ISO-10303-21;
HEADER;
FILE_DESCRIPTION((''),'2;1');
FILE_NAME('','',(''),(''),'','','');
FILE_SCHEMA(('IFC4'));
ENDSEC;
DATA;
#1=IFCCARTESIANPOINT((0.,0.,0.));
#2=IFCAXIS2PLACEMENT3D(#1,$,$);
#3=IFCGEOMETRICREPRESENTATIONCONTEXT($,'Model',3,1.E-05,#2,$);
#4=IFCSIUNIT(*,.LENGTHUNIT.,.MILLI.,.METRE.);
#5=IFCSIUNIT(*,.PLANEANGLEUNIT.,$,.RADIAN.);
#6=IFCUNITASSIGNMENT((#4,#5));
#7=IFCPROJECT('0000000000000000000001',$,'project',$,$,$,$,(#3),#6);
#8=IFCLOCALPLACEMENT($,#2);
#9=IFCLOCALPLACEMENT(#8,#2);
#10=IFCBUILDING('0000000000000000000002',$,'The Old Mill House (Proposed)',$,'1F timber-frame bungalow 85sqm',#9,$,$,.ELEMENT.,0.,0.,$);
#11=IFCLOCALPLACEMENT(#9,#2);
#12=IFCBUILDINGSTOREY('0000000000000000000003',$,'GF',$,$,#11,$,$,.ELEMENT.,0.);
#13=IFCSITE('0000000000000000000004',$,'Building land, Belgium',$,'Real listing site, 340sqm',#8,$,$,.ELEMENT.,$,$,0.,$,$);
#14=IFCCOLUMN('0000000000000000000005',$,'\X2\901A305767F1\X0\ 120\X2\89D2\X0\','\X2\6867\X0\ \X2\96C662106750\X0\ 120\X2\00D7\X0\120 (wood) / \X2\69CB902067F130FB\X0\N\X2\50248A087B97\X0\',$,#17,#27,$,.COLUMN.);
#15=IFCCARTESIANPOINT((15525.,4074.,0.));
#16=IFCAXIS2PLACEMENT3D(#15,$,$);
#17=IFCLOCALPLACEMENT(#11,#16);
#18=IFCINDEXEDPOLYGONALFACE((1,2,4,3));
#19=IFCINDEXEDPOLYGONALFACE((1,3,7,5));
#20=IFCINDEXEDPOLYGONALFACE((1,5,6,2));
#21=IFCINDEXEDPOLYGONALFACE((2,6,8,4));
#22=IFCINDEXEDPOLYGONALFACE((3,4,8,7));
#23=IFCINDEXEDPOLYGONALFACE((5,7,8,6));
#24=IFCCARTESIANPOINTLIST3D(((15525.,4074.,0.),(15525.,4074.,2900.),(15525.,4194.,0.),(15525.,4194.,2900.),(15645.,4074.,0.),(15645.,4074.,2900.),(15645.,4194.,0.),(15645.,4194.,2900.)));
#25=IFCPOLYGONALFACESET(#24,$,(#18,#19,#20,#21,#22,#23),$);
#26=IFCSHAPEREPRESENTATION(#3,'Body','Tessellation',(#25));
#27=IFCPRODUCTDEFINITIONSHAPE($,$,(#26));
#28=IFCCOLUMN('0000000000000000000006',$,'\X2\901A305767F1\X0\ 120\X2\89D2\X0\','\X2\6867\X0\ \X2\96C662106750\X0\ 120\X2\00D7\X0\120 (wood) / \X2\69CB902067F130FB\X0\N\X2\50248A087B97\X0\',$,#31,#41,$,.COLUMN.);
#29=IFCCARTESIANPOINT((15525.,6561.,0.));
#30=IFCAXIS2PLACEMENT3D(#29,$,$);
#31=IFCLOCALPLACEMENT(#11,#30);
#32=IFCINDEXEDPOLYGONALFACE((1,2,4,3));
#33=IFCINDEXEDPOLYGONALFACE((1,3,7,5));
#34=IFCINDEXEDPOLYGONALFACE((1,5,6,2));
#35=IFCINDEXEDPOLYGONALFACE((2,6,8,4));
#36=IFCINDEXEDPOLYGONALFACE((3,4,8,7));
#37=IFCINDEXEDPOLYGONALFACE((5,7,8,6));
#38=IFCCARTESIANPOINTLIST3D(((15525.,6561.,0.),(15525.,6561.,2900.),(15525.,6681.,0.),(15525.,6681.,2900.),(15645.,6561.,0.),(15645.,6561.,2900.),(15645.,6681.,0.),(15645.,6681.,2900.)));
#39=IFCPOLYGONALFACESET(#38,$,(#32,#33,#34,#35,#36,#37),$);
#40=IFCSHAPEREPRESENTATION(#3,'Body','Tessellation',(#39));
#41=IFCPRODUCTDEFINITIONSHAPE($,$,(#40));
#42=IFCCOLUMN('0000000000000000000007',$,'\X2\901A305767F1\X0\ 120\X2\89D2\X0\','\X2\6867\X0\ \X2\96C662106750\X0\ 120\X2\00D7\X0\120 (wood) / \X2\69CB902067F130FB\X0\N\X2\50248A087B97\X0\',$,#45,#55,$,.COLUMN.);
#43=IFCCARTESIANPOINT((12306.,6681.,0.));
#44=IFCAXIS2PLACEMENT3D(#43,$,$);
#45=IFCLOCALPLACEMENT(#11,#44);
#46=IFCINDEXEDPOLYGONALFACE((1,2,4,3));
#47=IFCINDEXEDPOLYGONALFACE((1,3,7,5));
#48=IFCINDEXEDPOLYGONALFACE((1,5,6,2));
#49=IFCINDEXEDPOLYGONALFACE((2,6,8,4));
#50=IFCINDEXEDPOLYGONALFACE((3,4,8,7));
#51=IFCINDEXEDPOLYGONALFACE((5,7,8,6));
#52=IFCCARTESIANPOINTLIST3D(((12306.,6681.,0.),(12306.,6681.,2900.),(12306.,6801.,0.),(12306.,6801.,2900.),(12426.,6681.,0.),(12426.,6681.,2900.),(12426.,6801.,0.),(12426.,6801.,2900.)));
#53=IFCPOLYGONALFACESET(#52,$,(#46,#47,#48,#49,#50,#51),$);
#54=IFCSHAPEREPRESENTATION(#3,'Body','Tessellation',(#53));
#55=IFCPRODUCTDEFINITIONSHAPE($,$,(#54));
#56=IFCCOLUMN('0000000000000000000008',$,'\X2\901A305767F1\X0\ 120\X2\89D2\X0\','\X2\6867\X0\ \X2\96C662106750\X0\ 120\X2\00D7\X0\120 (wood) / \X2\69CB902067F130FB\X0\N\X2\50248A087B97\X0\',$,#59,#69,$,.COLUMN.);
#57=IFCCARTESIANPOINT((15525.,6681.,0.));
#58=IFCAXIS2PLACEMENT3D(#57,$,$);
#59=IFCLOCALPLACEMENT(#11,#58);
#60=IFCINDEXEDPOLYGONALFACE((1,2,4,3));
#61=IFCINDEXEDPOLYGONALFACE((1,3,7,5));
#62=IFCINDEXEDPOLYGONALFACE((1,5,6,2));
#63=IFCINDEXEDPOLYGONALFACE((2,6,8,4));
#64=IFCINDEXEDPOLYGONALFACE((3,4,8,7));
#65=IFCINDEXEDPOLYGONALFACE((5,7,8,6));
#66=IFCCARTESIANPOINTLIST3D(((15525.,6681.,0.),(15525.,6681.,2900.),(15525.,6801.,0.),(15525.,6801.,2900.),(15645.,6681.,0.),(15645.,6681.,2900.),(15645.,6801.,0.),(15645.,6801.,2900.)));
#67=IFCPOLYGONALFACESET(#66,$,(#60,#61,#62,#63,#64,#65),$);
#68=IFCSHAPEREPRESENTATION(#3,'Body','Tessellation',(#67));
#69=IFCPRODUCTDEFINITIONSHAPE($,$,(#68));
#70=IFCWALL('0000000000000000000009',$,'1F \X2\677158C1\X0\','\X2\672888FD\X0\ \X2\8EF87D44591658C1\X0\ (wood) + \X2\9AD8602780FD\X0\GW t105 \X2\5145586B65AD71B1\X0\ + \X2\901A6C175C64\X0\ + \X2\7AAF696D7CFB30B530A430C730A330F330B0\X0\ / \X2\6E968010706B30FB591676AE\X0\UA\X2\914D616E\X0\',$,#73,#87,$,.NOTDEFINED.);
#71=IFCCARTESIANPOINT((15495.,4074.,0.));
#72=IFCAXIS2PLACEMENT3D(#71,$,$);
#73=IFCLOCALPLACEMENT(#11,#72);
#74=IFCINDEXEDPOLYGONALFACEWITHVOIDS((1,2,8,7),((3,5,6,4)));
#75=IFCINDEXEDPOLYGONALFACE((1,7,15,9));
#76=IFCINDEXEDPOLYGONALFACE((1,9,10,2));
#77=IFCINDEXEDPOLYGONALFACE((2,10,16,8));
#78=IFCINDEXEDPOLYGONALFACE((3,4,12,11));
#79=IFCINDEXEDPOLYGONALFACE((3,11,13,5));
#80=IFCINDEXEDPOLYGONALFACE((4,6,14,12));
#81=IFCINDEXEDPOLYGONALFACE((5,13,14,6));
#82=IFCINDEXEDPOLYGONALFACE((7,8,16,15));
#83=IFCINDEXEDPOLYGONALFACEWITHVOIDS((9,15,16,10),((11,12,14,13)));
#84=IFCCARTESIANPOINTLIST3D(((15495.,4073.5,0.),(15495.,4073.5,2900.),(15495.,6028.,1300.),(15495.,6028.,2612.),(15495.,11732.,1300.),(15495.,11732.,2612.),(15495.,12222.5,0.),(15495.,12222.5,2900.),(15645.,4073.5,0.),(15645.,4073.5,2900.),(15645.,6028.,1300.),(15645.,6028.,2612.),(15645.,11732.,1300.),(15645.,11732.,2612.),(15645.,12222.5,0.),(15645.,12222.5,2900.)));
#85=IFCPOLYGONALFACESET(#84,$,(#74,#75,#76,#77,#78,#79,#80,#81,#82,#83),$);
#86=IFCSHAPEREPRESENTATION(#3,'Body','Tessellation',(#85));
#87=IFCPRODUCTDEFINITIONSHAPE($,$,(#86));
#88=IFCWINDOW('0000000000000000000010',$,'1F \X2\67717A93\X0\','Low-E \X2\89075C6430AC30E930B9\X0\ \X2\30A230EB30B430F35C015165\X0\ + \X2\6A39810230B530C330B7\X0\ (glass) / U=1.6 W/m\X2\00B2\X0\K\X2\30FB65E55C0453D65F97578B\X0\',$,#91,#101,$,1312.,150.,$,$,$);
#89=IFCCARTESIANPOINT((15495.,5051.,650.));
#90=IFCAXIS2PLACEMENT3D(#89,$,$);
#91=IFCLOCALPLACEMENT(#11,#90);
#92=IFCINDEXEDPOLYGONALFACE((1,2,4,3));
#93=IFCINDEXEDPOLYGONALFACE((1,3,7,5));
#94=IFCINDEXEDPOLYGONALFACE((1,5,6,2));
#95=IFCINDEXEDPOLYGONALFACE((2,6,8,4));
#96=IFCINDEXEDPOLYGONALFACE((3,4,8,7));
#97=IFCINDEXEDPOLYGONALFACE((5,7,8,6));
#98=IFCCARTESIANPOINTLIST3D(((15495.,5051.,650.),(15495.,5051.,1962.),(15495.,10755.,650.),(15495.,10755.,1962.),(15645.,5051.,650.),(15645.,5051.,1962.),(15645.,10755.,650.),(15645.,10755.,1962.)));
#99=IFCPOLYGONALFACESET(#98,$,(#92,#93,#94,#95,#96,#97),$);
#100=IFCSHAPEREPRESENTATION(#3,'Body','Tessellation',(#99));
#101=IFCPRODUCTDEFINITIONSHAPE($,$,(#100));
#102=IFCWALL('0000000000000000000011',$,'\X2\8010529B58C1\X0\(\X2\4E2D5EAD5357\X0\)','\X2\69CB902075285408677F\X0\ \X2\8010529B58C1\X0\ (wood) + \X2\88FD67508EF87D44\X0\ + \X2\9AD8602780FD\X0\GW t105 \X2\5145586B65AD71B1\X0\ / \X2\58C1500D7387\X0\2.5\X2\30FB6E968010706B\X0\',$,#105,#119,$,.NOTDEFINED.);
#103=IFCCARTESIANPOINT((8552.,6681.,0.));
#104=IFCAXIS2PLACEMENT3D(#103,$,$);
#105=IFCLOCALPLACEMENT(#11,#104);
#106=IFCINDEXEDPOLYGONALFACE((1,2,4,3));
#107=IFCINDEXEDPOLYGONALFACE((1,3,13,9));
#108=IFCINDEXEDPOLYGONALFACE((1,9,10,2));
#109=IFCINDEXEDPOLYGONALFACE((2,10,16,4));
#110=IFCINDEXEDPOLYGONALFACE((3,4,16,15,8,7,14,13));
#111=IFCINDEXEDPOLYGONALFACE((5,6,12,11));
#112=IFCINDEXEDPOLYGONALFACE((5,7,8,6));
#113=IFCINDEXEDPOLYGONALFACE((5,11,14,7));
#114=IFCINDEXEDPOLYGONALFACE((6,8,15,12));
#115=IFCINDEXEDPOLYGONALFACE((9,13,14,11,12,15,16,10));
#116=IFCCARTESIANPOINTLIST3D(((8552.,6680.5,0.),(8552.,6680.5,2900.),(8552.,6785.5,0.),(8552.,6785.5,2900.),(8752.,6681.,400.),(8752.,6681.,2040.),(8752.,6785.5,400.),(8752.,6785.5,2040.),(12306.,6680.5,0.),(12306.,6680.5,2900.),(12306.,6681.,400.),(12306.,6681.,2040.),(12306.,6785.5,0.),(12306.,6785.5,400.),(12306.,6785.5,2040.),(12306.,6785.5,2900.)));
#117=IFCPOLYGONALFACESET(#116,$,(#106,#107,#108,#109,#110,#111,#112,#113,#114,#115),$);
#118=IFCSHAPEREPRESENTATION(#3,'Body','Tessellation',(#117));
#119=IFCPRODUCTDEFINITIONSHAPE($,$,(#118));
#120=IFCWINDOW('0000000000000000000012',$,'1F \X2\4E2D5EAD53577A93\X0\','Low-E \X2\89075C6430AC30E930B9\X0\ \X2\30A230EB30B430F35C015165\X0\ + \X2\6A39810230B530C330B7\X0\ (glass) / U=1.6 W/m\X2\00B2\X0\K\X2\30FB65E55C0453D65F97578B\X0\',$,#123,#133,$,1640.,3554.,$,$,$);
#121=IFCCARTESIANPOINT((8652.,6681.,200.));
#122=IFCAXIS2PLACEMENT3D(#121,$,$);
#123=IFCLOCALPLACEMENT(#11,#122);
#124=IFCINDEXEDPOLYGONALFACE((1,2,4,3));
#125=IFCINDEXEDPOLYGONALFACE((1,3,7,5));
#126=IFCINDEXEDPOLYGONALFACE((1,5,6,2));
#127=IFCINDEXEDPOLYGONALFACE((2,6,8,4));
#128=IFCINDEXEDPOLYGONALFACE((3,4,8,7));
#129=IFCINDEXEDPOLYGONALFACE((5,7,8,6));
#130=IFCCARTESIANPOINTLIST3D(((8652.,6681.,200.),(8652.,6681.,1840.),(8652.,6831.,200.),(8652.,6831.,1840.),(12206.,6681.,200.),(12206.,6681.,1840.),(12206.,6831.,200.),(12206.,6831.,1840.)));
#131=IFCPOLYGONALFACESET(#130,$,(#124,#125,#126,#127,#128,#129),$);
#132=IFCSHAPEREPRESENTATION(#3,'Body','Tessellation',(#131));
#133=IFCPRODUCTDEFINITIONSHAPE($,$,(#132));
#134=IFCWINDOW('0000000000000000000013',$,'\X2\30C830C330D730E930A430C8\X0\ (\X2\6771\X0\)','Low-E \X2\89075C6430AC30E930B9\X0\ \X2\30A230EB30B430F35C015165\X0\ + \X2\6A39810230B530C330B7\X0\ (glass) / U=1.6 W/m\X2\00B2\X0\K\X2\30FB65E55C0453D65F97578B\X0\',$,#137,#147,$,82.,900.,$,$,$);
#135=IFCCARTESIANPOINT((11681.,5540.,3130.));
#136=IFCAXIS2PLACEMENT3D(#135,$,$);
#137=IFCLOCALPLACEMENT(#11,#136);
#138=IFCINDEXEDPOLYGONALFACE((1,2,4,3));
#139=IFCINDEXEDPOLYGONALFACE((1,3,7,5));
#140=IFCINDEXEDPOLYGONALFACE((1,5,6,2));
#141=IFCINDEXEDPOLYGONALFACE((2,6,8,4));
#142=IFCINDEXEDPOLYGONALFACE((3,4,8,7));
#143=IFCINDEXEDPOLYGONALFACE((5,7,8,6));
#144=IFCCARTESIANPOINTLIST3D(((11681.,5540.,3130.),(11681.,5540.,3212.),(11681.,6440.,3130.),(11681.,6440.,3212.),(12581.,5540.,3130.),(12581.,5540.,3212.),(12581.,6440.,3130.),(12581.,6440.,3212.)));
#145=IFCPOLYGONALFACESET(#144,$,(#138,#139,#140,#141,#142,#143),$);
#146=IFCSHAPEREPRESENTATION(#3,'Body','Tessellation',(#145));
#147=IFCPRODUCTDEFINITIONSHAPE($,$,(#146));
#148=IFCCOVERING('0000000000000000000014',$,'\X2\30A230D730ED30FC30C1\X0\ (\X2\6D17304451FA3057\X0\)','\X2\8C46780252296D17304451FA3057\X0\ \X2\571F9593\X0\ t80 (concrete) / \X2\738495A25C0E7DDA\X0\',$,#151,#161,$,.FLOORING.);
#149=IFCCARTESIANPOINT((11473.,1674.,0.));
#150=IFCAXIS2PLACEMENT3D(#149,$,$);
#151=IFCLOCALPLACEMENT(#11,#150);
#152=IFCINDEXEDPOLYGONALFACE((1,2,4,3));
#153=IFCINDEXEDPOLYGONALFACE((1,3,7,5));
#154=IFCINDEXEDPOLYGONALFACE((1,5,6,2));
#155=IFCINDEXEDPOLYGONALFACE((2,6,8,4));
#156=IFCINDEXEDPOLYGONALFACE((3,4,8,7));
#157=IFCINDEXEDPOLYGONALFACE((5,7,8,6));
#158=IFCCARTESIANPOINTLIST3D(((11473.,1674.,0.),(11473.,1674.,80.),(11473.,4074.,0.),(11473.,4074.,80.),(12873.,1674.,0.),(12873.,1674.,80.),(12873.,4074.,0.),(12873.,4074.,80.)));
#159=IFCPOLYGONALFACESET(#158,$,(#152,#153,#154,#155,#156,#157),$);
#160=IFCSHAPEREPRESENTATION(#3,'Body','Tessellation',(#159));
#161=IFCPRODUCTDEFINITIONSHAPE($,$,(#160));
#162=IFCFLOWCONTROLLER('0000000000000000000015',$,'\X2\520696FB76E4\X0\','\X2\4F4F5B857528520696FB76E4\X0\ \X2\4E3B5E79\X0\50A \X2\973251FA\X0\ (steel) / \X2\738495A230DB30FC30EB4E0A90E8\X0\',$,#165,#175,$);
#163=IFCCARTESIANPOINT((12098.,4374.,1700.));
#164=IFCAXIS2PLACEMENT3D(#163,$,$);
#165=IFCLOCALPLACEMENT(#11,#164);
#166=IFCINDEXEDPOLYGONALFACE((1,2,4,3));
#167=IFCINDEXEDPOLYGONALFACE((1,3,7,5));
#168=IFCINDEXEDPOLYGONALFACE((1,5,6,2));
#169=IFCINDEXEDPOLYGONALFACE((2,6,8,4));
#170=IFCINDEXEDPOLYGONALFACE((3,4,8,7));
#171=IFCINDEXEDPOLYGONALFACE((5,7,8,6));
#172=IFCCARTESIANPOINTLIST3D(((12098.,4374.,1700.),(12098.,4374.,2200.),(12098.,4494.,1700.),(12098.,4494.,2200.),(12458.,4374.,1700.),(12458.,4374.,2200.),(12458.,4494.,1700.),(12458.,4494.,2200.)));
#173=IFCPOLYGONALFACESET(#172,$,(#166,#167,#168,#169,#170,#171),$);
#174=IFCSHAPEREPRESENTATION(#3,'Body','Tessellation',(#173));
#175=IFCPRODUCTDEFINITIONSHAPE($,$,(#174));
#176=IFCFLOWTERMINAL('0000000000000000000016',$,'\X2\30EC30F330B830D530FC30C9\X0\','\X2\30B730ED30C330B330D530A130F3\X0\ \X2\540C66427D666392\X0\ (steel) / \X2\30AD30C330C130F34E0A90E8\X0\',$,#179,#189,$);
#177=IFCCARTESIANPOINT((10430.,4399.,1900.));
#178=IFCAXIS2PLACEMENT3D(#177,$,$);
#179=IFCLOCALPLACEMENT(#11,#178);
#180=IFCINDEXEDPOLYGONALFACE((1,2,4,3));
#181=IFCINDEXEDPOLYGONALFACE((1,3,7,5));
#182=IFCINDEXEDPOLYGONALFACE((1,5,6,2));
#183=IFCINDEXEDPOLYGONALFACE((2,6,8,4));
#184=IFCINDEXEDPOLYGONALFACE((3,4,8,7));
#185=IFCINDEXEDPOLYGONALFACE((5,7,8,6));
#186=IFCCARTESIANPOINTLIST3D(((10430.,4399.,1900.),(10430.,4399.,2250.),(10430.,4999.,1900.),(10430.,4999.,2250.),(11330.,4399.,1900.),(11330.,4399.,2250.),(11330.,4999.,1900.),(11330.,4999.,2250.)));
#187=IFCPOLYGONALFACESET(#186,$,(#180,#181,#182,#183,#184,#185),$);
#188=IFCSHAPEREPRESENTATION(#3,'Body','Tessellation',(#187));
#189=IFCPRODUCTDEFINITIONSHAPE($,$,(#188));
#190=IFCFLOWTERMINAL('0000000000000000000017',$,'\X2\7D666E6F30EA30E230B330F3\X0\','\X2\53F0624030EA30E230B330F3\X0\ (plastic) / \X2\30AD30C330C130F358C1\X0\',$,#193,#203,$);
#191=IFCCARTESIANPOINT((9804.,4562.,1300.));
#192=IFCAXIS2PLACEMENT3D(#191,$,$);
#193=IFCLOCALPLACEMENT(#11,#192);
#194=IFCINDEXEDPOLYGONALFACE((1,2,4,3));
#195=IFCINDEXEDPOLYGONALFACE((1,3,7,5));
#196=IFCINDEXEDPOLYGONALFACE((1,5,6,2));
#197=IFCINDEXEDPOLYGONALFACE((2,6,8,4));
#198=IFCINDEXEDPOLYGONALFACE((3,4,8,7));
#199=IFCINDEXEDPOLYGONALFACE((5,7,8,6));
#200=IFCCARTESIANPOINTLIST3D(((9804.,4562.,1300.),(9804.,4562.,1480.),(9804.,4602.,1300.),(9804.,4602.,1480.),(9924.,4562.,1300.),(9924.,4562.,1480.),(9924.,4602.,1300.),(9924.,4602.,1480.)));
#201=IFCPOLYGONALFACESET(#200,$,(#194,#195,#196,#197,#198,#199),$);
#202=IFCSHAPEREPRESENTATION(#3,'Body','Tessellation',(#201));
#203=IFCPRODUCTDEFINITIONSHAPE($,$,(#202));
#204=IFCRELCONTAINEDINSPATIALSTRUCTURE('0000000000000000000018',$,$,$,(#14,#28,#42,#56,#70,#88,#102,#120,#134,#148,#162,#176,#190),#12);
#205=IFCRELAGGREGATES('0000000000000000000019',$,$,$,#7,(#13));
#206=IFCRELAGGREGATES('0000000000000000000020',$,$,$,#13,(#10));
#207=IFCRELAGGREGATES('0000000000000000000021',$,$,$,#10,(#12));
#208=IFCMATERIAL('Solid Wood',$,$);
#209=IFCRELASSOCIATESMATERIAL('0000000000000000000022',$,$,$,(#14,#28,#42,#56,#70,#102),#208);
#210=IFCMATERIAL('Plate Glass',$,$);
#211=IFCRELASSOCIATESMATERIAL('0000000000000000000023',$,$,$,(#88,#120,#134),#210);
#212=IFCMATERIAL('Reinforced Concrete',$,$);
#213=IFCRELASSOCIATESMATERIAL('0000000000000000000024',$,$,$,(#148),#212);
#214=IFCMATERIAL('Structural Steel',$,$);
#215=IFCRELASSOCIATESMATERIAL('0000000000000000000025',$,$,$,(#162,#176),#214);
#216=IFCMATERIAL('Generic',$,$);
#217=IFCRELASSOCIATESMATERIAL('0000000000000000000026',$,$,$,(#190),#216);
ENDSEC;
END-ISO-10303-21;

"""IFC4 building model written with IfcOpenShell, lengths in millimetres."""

from ifc_helpers import new_model, si_unit, frame, frame_2d, origin, place, context, project, spatial, rectangle, extrude, material, element, fill, save


model = new_model("IFC4")

# Units and contexts
model_context = context("Model", 3, precision=1e-05, world=origin())
ifc_project = project(units=[si_unit("LENGTHUNIT", "METRE", prefix="MILLI"), si_unit("PLANEANGLEUNIT", "RADIAN")], contexts=[model_context])

# Site, building, storey
site_placement = place(None, origin())
site = spatial("IfcSite", under=ifc_project, at=site_placement, Name="Building land, Belgium", ObjectType="Real listing site, 340sqm", CompositionType="ELEMENT", RefElevation=0.0)
building_placement = place(site_placement, origin())
building = spatial("IfcBuilding", under=site, at=building_placement, Name="The Old Mill House (Proposed)", ObjectType="1F timber-frame bungalow 85sqm", CompositionType="ELEMENT", ElevationOfRefHeight=0.0, ElevationOfTerrain=0.0)
storey_placement = place(building_placement, origin())
storey = spatial("IfcBuildingStorey", under=building, at=storey_placement, Name="GF", CompositionType="ELEMENT", Elevation=0.0)

# Columns
ifc_material_1 = material(Name="Solid Wood")
column_1_placement = place(storey_placement, frame((15525.0, 4074.0, 0.0)))
element("IfcColumn", 1, at=column_1_placement, inside=storey, material=ifc_material_1, Name="通し柱 120角", Description="桧 集成材 120×120 (wood) / 構造柱・N値計算", PredefinedType="COLUMN", context=model_context, shape_type="SweptSolid", body=[
    extrude(rectangle(XDim=120.0, YDim=120.0, at=frame_2d((60.0, 60.0))), frame((15525.0, 4074.0, 0.0)), (0.0, 0.0, 1.0), 2900.0),
])
column_2_placement = place(storey_placement, frame((15525.0, 6561.0, 0.0)))
element("IfcColumn", 2, at=column_2_placement, inside=storey, material=ifc_material_1, Name="通し柱 120角", Description="桧 集成材 120×120 (wood) / 構造柱・N値計算", PredefinedType="COLUMN", context=model_context, shape_type="SweptSolid", body=[
    extrude(rectangle(XDim=120.0, YDim=120.0, at=frame_2d((60.0, 60.0))), frame((15525.0, 6561.0, 0.0)), (0.0, 0.0, 1.0), 2900.0),
])
column_3_placement = place(storey_placement, frame((12306.0, 6681.0, 0.0)))
element("IfcColumn", 3, at=column_3_placement, inside=storey, material=ifc_material_1, Name="通し柱 120角", Description="桧 集成材 120×120 (wood) / 構造柱・N値計算", PredefinedType="COLUMN", context=model_context, shape_type="SweptSolid", body=[
    extrude(rectangle(XDim=120.0, YDim=120.0, at=frame_2d((60.0, 60.0))), frame((12306.0, 6681.0, 0.0)), (0.0, 0.0, 1.0), 2900.0),
])
column_4_placement = place(storey_placement, frame((15525.0, 6681.0, 0.0)))
element("IfcColumn", 4, at=column_4_placement, inside=storey, material=ifc_material_1, Name="通し柱 120角", Description="桧 集成材 120×120 (wood) / 構造柱・N値計算", PredefinedType="COLUMN", context=model_context, shape_type="SweptSolid", body=[
    extrude(rectangle(XDim=120.0, YDim=120.0, at=frame_2d((60.0, 60.0))), frame((15525.0, 6681.0, 0.0)), (0.0, 0.0, 1.0), 2900.0),
])

# Walls, openings, windows
wall_1_placement = place(storey_placement, frame((15495.0, 4074.0, 0.0)))
wall_1 = element("IfcWall", 5, at=wall_1_placement, inside=storey, material=ifc_material_1, Name="1F 東壁", Description="木製 軸組外壁 (wood) + 高性能GW t105 充填断熱 + 通気層 + 窯業系サイディング / 準耐火・外皮UA配慮", PredefinedType="NOTDEFINED", context=model_context, shape_type="SweptSolid", body=[
    extrude(rectangle(XDim=150.0, YDim=8149.0, at=frame_2d((75.0, 4074.0))), frame((15495.0, 4074.0, 0.0)), (0.0, 0.0, 1.0), 2900.0),
])
opening_1_placement = place(storey_placement, frame((15495.0, 5051.0, 650.0)))
opening_1 = element("IfcOpeningElement", 6, at=opening_1_placement, cuts=wall_1, PredefinedType="NOTDEFINED", context=model_context, shape_type="SweptSolid", body=[
    extrude(rectangle(XDim=150.0, YDim=5704.0, at=frame_2d((75.0, 2852.0))), frame((15495.0, 5051.0, 650.0)), (0.0, 0.0, 1.0), 1312.0),
])
ifc_material_2 = material(Name="Plate Glass")
window_1_placement = place(storey_placement, frame((15495.0, 5051.0, 650.0)))
window_1 = element("IfcWindow", 7, at=window_1_placement, inside=storey, material=ifc_material_2, Name="1F 東窓", Description="Low-E 複層ガラス アルゴン封入 + 樹脂サッシ (glass) / U=1.6 W/m²K・日射取得型", OverallHeight=1312.0, OverallWidth=150.0, context=model_context, shape_type="SweptSolid", body=[
    extrude(rectangle(XDim=150.0, YDim=5704.0, at=frame_2d((75.0, 2852.0))), frame((15495.0, 5051.0, 650.0)), (0.0, 0.0, 1.0), 1312.0),
])
fill(opening_1, window_1)
wall_2_placement = place(storey_placement, frame((8552.0, 6681.0, 0.0)))
wall_2 = element("IfcWall", 8, at=wall_2_placement, inside=storey, material=ifc_material_1, Name="耐力壁(中庭南)", Description="構造用合板 耐力壁 (wood) + 製材軸組 + 高性能GW t105 充填断熱 / 壁倍率2.5・準耐火", PredefinedType="NOTDEFINED", context=model_context, shape_type="SweptSolid", body=[
    extrude(rectangle(XDim=3754.0, YDim=105.0, at=frame_2d((1877.0, 52.0))), frame((8552.0, 6681.0, 0.0)), (0.0, 0.0, 1.0), 2900.0),
])
opening_2_placement = place(storey_placement, frame((8652.0, 6681.0, 200.0)))
opening_2 = element("IfcOpeningElement", 9, at=opening_2_placement, cuts=wall_2, PredefinedType="NOTDEFINED", context=model_context, shape_type="SweptSolid", body=[
    extrude(rectangle(XDim=3554.0, YDim=150.0, at=frame_2d((1777.0, 75.0))), frame((8652.0, 6681.0, 200.0)), (0.0, 0.0, 1.0), 1640.0),
])
window_2_placement = place(storey_placement, frame((8652.0, 6681.0, 200.0)))
window_2 = element("IfcWindow", 10, at=window_2_placement, inside=storey, material=ifc_material_2, Name="1F 中庭南窓", Description="Low-E 複層ガラス アルゴン封入 + 樹脂サッシ (glass) / U=1.6 W/m²K・日射取得型", OverallHeight=1640.0, OverallWidth=3554.0, context=model_context, shape_type="SweptSolid", body=[
    extrude(rectangle(XDim=3554.0, YDim=150.0, at=frame_2d((1777.0, 75.0))), frame((8652.0, 6681.0, 200.0)), (0.0, 0.0, 1.0), 1640.0),
])
fill(opening_2, window_2)

# Window
window_3_placement = place(storey_placement, frame((11681.0, 5540.0, 3130.0)))
element("IfcWindow", 11, at=window_3_placement, inside=storey, material=ifc_material_2, Name="トップライト (東)", Description="Low-E 複層ガラス アルゴン封入 + 樹脂サッシ (glass) / U=1.6 W/m²K・日射取得型", OverallHeight=82.0, OverallWidth=900.0, context=model_context, shape_type="SweptSolid", body=[
    extrude(rectangle(XDim=900.0, YDim=900.0, at=frame_2d((450.0, 450.0))), frame((11681.0, 5540.0, 3130.0)), (0.0, 0.0, 1.0), 82.0),
])

# Shared definitions
ifc_material_3 = material(Name="Structural Steel")

# Covering
ifc_material_4 = material(Name="Reinforced Concrete")
covering_placement = place(storey_placement, frame((11473.0, 1674.0, 0.0)))
element("IfcCovering", 12, at=covering_placement, inside=storey, material=ifc_material_4, Name="アプローチ (洗い出し)", Description="豆砂利洗い出し 土間 t80 (concrete) / 玄関導線", PredefinedType="FLOORING", context=model_context, shape_type="SweptSolid", body=[
    extrude(rectangle(XDim=1400.0, YDim=2400.0, at=frame_2d((700.0, 1200.0))), frame((11473.0, 1674.0, 0.0)), (0.0, 0.0, 1.0), 80.0),
])

# Flow controller
flow_controller_placement = place(storey_placement, frame((12098.0, 4374.0, 1700.0)))
element("IfcFlowController", 13, at=flow_controller_placement, inside=storey, material=ifc_material_3, Name="分電盤", Description="住宅用分電盤 主幹50A 露出 (steel) / 玄関ホール上部", context=model_context, shape_type="SweptSolid", body=[
    extrude(rectangle(XDim=360.0, YDim=120.0, at=frame_2d((180.0, 60.0))), frame((12098.0, 4374.0, 1700.0)), (0.0, 0.0, 1.0), 500.0),
])

# Flow terminals
flow_terminal_1_placement = place(storey_placement, frame((10430.0, 4399.0, 1900.0)))
element("IfcFlowTerminal", 14, at=flow_terminal_1_placement, inside=storey, material=ifc_material_3, Name="レンジフード", Description="シロッコファン 同時給排 (steel) / キッチン上部", context=model_context, shape_type="SweptSolid", body=[
    extrude(rectangle(XDim=900.0, YDim=600.0, at=frame_2d((450.0, 300.0))), frame((10430.0, 4399.0, 1900.0)), (0.0, 0.0, 1.0), 350.0),
])
ifc_material_5 = material(Name="Generic")
flow_terminal_2_placement = place(storey_placement, frame((9804.0, 4562.0, 1300.0)))
element("IfcFlowTerminal", 15, at=flow_terminal_2_placement, inside=storey, material=ifc_material_5, Name="給湯リモコン", Description="台所リモコン (plastic) / キッチン壁", context=model_context, shape_type="SweptSolid", body=[
    extrude(rectangle(XDim=120.0, YDim=40.0, at=frame_2d((60.0, 20.0))), frame((9804.0, 4562.0, 1300.0)), (0.0, 0.0, 1.0), 180.0),
])

save(model, "model.ifc")
